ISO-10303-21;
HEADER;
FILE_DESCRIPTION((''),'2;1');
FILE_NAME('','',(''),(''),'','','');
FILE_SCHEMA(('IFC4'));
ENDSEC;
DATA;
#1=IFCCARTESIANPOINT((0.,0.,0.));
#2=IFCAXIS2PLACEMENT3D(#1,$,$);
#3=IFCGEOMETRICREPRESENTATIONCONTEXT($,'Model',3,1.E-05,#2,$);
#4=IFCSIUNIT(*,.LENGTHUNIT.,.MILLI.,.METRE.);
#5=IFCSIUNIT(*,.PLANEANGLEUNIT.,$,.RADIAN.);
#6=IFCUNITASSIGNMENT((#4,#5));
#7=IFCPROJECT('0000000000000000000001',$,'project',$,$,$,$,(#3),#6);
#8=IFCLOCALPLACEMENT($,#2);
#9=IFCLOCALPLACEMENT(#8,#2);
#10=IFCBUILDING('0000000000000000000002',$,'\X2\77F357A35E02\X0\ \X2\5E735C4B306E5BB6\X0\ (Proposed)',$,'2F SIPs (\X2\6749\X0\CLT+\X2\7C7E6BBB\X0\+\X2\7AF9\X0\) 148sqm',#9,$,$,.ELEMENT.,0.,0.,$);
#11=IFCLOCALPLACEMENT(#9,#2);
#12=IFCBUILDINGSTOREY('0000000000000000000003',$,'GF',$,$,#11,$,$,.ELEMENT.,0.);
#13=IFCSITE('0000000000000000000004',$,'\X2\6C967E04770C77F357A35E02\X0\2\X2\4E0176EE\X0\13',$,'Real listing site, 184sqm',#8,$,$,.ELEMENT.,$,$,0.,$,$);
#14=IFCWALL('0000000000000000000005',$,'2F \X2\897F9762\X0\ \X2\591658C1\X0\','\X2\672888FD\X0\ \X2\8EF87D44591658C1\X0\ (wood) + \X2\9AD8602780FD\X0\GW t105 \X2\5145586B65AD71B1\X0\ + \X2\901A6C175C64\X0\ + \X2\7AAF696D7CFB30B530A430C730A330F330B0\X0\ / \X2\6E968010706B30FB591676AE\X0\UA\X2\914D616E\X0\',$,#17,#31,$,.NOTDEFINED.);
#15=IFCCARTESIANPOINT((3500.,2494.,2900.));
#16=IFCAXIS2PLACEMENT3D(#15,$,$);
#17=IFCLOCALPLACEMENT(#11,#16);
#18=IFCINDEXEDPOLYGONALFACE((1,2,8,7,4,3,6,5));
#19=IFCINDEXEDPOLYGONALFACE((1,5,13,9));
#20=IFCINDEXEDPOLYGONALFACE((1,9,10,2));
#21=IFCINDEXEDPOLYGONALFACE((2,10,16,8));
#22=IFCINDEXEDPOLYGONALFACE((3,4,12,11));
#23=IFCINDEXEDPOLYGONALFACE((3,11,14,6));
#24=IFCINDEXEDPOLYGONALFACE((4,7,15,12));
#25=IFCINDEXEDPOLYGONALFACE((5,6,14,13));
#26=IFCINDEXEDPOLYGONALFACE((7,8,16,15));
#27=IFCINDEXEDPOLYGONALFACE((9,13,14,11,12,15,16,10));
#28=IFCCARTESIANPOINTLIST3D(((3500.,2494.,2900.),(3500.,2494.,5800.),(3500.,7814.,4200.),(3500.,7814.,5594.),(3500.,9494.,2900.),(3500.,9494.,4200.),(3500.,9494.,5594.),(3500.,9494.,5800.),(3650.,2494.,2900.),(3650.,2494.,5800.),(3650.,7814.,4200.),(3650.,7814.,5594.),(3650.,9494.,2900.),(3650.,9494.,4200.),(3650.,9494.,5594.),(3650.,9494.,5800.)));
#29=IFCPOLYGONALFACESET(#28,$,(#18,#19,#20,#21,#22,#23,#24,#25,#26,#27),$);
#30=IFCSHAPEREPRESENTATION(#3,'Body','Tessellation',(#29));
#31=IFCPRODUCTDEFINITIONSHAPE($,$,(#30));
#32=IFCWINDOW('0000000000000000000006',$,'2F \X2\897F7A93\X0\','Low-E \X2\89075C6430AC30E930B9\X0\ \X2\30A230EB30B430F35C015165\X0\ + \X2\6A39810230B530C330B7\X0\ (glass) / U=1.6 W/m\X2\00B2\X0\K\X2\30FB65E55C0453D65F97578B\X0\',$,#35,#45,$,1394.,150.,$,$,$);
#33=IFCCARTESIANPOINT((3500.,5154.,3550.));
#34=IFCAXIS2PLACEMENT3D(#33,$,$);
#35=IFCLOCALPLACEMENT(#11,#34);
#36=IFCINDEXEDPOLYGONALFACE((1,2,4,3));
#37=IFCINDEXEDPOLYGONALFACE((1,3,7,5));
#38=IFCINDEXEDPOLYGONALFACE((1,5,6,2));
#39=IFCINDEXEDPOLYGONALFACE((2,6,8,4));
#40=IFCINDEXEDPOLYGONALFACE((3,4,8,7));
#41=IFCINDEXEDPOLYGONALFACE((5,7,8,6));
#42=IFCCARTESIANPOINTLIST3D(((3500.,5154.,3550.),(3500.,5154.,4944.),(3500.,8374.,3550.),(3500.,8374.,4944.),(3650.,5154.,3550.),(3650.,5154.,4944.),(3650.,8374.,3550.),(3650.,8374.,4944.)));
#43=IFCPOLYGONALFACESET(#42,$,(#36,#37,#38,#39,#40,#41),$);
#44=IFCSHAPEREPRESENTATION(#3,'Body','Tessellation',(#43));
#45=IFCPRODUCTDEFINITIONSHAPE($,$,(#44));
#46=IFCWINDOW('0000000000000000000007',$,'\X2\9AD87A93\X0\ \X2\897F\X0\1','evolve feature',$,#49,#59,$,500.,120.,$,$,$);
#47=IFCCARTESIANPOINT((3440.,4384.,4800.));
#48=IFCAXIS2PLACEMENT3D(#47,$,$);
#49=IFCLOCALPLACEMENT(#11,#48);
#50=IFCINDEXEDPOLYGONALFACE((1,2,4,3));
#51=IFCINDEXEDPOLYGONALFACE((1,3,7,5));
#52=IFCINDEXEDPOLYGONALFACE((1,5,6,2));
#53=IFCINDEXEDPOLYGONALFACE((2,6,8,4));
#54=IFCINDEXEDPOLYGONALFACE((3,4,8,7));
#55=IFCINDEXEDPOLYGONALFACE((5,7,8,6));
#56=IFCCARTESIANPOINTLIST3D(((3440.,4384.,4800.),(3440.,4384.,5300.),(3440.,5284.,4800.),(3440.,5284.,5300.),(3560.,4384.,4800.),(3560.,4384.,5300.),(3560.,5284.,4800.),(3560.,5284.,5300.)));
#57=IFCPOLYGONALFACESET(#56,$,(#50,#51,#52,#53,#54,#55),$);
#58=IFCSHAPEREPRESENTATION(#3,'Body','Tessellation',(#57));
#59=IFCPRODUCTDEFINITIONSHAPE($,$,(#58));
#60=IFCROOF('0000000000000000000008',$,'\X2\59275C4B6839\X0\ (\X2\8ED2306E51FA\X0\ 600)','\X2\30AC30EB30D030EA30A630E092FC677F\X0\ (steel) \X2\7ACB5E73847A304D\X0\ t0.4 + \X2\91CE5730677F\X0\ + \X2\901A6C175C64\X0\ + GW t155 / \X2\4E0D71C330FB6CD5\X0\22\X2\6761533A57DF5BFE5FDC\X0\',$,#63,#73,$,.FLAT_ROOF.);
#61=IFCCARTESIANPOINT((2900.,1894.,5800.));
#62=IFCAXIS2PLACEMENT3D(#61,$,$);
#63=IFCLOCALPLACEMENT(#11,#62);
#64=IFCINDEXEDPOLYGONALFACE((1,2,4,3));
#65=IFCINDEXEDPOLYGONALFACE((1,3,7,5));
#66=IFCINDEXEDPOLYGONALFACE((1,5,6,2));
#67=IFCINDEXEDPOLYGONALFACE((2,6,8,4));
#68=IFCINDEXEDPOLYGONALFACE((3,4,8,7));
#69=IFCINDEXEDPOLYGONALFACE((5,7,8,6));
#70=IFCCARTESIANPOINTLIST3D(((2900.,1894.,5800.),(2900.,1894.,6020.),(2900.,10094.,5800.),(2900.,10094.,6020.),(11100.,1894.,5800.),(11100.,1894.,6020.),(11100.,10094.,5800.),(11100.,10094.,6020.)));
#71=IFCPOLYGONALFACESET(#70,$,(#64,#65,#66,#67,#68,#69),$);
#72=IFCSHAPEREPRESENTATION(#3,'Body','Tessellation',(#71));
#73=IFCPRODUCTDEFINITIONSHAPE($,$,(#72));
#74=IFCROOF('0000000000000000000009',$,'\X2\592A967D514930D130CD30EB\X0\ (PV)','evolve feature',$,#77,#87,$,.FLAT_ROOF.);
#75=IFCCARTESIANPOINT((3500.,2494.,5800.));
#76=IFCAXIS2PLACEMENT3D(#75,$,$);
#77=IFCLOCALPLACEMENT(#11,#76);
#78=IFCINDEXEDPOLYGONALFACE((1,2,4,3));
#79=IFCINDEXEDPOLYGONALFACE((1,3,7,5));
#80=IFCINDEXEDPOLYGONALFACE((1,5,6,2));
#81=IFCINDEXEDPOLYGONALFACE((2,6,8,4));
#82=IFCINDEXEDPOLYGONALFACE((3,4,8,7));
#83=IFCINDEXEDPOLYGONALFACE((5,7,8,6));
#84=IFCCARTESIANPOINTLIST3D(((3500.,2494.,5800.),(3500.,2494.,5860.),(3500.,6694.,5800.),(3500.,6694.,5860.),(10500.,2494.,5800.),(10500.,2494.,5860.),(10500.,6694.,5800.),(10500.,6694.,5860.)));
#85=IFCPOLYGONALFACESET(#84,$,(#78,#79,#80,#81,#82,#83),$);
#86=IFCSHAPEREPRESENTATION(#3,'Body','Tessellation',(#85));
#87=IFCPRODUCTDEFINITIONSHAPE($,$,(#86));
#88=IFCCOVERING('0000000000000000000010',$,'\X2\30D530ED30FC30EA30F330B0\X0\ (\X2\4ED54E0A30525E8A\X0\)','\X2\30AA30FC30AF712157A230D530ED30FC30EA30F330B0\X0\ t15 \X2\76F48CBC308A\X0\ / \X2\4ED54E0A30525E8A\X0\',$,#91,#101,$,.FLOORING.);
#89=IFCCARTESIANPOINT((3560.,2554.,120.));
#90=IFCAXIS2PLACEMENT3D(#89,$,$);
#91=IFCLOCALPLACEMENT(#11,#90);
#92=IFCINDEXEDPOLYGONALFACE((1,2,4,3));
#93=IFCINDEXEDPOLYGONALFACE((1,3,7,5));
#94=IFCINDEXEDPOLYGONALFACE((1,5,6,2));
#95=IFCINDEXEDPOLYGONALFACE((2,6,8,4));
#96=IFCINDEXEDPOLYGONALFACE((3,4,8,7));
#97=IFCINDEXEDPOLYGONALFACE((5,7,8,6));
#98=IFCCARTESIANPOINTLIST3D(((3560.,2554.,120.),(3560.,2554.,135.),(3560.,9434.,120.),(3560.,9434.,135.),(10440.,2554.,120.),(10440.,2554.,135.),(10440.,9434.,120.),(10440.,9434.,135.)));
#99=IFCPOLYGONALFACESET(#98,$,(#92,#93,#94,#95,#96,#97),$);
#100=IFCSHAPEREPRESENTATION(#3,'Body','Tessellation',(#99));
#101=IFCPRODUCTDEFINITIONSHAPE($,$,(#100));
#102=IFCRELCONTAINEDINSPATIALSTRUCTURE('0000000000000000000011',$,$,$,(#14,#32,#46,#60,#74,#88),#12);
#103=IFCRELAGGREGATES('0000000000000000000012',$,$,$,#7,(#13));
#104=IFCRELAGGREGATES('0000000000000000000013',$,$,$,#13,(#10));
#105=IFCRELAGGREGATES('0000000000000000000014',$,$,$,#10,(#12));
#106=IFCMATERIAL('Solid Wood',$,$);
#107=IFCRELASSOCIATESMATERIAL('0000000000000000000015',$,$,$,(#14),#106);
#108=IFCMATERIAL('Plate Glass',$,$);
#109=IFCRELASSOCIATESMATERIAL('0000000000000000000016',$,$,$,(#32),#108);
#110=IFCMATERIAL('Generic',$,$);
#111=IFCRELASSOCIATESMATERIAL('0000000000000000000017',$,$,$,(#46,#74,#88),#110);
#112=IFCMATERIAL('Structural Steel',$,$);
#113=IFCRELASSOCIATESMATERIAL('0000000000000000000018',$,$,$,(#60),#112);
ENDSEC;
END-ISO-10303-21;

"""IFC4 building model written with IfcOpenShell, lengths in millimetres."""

from ifc_helpers import new_model, si_unit, frame, frame_2d, origin, place, context, project, spatial, rectangle, extrude, material, element, fill, save


model = new_model("IFC4")

# Units and contexts
model_context = context("Model", 3, precision=1e-05, world=origin())
ifc_project = project(units=[si_unit("LENGTHUNIT", "METRE", prefix="MILLI"), si_unit("PLANEANGLEUNIT", "RADIAN")], contexts=[model_context])

# Site, building, storey
site_placement = place(None, origin())
site = spatial("IfcSite", under=ifc_project, at=site_placement, Name="沖縄県石垣市2丁目13", ObjectType="Real listing site, 184sqm", CompositionType="ELEMENT", RefElevation=0.0)
building_placement = place(site_placement, origin())
building = spatial("IfcBuilding", under=site, at=building_placement, Name="石垣市 平屋の家 (Proposed)", ObjectType="2F SIPs (杉CLT+籾殻+竹) 148sqm", CompositionType="ELEMENT", ElevationOfRefHeight=0.0, ElevationOfTerrain=0.0)
storey_placement = place(building_placement, origin())
storey = spatial("IfcBuildingStorey", under=building, at=storey_placement, Name="GF", CompositionType="ELEMENT", Elevation=0.0)

# Shared definitions
ifc_material_1 = material(Name="Solid Wood")

# Shared definitions
ifc_material_2 = material(Name="Plate Glass")
ifc_material_3 = material(Name="Generic")

# Wall, openings, windows
wall_1_placement = place(storey_placement, frame((3500.0, 2494.0, 2900.0)))
wall_1 = element("IfcWall", 1, at=wall_1_placement, inside=storey, material=ifc_material_1, Name="2F 西面 外壁", Description="木製 軸組外壁 (wood) + 高性能GW t105 充填断熱 + 通気層 + 窯業系サイディング / 準耐火・外皮UA配慮", PredefinedType="NOTDEFINED", context=model_context, shape_type="SweptSolid", body=[
    extrude(rectangle(XDim=150.0, YDim=7000.0, at=frame_2d((75.0, 3500.0))), frame((3500.0, 2494.0, 2900.0)), (0.0, 0.0, 1.0), 2900.0),
])
opening_1_placement = place(storey_placement, frame((3500.0, 5154.0, 3550.0)))
opening_1 = element("IfcOpeningElement", 2, at=opening_1_placement, cuts=wall_1, PredefinedType="NOTDEFINED", context=model_context, shape_type="SweptSolid", body=[
    extrude(rectangle(XDim=150.0, YDim=3220.0, at=frame_2d((75.0, 1610.0))), frame((3500.0, 5154.0, 3550.0)), (0.0, 0.0, 1.0), 1394.0),
])
opening_2_placement = place(storey_placement, frame((3440.0, 4384.0, 4800.0)))
opening_2 = element("IfcOpeningElement", 3, at=opening_2_placement, cuts=wall_1, PredefinedType="NOTDEFINED", context=model_context, shape_type="SweptSolid", body=[
    extrude(rectangle(XDim=120.0, YDim=900.0, at=frame_2d((60.0, 450.0))), frame((3440.0, 4384.0, 4800.0)), (0.0, 0.0, 1.0), 500.0),
])
window_1_placement = place(storey_placement, frame((3500.0, 5154.0, 3550.0)))
window_1 = element("IfcWindow", 4, at=window_1_placement, inside=storey, material=ifc_material_2, Name="2F 西窓", Description="Low-E 複層ガラス アルゴン封入 + 樹脂サッシ (glass) / U=1.6 W/m²K・日射取得型", OverallHeight=1394.0, OverallWidth=150.0, context=model_context, shape_type="SweptSolid", body=[
    extrude(rectangle(XDim=150.0, YDim=3220.0, at=frame_2d((75.0, 1610.0))), frame((3500.0, 5154.0, 3550.0)), (0.0, 0.0, 1.0), 1394.0),
])
fill(opening_1, window_1)
window_2_placement = place(storey_placement, frame((3440.0, 4384.0, 4800.0)))
window_2 = element("IfcWindow", 5, at=window_2_placement, inside=storey, material=ifc_material_3, Name="高窓 西1", Description="evolve feature", OverallHeight=500.0, OverallWidth=120.0, context=model_context, shape_type="SweptSolid", body=[
    extrude(rectangle(XDim=120.0, YDim=900.0, at=frame_2d((60.0, 450.0))), frame((3440.0, 4384.0, 4800.0)), (0.0, 0.0, 1.0), 500.0),
])
fill(opening_2, window_2)

# Roofs
ifc_material_4 = material(Name="Structural Steel")
roof_1_placement = place(storey_placement, frame((2900.0, 1894.0, 5800.0)))
element("IfcRoof", 6, at=roof_1_placement, inside=storey, material=ifc_material_4, Name="大屋根 (軒の出 600)", Description="ガルバリウム鋼板 (steel) 立平葺き t0.4 + 野地板 + 通気層 + GW t155 / 不燃・法22条区域対応", PredefinedType="FLAT_ROOF", context=model_context, shape_type="SweptSolid", body=[
    extrude(rectangle(XDim=8200.0, YDim=8200.0, at=frame_2d((4100.0, 4100.0))), frame((2900.0, 1894.0, 5800.0)), (0.0, 0.0, 1.0), 220.0),
])
roof_2_placement = place(storey_placement, frame((3500.0, 2494.0, 5800.0)))
element("IfcRoof", 7, at=roof_2_placement, inside=storey, material=ifc_material_3, Name="太陽光パネル (PV)", Description="evolve feature", PredefinedType="FLAT_ROOF", context=model_context, shape_type="SweptSolid", body=[
    extrude(rectangle(XDim=7000.0, YDim=4200.0, at=frame_2d((3500.0, 2100.0))), frame((3500.0, 2494.0, 5800.0)), (0.0, 0.0, 1.0), 60.0),
])

# Covering
covering_placement = place(storey_placement, frame((3560.0, 2554.0, 120.0)))
element("IfcCovering", 8, at=covering_placement, inside=storey, material=ifc_material_3, Name="フローリング (仕上げ床)", Description="オーク無垢フローリング t15 直貼り / 仕上げ床", PredefinedType="FLOORING", context=model_context, shape_type="SweptSolid", body=[
    extrude(rectangle(XDim=6880.0, YDim=6880.0, at=frame_2d((3440.0, 3440.0))), frame((3560.0, 2554.0, 120.0)), (0.0, 0.0, 1.0), 15.0),
])

save(model, "model.ifc")
